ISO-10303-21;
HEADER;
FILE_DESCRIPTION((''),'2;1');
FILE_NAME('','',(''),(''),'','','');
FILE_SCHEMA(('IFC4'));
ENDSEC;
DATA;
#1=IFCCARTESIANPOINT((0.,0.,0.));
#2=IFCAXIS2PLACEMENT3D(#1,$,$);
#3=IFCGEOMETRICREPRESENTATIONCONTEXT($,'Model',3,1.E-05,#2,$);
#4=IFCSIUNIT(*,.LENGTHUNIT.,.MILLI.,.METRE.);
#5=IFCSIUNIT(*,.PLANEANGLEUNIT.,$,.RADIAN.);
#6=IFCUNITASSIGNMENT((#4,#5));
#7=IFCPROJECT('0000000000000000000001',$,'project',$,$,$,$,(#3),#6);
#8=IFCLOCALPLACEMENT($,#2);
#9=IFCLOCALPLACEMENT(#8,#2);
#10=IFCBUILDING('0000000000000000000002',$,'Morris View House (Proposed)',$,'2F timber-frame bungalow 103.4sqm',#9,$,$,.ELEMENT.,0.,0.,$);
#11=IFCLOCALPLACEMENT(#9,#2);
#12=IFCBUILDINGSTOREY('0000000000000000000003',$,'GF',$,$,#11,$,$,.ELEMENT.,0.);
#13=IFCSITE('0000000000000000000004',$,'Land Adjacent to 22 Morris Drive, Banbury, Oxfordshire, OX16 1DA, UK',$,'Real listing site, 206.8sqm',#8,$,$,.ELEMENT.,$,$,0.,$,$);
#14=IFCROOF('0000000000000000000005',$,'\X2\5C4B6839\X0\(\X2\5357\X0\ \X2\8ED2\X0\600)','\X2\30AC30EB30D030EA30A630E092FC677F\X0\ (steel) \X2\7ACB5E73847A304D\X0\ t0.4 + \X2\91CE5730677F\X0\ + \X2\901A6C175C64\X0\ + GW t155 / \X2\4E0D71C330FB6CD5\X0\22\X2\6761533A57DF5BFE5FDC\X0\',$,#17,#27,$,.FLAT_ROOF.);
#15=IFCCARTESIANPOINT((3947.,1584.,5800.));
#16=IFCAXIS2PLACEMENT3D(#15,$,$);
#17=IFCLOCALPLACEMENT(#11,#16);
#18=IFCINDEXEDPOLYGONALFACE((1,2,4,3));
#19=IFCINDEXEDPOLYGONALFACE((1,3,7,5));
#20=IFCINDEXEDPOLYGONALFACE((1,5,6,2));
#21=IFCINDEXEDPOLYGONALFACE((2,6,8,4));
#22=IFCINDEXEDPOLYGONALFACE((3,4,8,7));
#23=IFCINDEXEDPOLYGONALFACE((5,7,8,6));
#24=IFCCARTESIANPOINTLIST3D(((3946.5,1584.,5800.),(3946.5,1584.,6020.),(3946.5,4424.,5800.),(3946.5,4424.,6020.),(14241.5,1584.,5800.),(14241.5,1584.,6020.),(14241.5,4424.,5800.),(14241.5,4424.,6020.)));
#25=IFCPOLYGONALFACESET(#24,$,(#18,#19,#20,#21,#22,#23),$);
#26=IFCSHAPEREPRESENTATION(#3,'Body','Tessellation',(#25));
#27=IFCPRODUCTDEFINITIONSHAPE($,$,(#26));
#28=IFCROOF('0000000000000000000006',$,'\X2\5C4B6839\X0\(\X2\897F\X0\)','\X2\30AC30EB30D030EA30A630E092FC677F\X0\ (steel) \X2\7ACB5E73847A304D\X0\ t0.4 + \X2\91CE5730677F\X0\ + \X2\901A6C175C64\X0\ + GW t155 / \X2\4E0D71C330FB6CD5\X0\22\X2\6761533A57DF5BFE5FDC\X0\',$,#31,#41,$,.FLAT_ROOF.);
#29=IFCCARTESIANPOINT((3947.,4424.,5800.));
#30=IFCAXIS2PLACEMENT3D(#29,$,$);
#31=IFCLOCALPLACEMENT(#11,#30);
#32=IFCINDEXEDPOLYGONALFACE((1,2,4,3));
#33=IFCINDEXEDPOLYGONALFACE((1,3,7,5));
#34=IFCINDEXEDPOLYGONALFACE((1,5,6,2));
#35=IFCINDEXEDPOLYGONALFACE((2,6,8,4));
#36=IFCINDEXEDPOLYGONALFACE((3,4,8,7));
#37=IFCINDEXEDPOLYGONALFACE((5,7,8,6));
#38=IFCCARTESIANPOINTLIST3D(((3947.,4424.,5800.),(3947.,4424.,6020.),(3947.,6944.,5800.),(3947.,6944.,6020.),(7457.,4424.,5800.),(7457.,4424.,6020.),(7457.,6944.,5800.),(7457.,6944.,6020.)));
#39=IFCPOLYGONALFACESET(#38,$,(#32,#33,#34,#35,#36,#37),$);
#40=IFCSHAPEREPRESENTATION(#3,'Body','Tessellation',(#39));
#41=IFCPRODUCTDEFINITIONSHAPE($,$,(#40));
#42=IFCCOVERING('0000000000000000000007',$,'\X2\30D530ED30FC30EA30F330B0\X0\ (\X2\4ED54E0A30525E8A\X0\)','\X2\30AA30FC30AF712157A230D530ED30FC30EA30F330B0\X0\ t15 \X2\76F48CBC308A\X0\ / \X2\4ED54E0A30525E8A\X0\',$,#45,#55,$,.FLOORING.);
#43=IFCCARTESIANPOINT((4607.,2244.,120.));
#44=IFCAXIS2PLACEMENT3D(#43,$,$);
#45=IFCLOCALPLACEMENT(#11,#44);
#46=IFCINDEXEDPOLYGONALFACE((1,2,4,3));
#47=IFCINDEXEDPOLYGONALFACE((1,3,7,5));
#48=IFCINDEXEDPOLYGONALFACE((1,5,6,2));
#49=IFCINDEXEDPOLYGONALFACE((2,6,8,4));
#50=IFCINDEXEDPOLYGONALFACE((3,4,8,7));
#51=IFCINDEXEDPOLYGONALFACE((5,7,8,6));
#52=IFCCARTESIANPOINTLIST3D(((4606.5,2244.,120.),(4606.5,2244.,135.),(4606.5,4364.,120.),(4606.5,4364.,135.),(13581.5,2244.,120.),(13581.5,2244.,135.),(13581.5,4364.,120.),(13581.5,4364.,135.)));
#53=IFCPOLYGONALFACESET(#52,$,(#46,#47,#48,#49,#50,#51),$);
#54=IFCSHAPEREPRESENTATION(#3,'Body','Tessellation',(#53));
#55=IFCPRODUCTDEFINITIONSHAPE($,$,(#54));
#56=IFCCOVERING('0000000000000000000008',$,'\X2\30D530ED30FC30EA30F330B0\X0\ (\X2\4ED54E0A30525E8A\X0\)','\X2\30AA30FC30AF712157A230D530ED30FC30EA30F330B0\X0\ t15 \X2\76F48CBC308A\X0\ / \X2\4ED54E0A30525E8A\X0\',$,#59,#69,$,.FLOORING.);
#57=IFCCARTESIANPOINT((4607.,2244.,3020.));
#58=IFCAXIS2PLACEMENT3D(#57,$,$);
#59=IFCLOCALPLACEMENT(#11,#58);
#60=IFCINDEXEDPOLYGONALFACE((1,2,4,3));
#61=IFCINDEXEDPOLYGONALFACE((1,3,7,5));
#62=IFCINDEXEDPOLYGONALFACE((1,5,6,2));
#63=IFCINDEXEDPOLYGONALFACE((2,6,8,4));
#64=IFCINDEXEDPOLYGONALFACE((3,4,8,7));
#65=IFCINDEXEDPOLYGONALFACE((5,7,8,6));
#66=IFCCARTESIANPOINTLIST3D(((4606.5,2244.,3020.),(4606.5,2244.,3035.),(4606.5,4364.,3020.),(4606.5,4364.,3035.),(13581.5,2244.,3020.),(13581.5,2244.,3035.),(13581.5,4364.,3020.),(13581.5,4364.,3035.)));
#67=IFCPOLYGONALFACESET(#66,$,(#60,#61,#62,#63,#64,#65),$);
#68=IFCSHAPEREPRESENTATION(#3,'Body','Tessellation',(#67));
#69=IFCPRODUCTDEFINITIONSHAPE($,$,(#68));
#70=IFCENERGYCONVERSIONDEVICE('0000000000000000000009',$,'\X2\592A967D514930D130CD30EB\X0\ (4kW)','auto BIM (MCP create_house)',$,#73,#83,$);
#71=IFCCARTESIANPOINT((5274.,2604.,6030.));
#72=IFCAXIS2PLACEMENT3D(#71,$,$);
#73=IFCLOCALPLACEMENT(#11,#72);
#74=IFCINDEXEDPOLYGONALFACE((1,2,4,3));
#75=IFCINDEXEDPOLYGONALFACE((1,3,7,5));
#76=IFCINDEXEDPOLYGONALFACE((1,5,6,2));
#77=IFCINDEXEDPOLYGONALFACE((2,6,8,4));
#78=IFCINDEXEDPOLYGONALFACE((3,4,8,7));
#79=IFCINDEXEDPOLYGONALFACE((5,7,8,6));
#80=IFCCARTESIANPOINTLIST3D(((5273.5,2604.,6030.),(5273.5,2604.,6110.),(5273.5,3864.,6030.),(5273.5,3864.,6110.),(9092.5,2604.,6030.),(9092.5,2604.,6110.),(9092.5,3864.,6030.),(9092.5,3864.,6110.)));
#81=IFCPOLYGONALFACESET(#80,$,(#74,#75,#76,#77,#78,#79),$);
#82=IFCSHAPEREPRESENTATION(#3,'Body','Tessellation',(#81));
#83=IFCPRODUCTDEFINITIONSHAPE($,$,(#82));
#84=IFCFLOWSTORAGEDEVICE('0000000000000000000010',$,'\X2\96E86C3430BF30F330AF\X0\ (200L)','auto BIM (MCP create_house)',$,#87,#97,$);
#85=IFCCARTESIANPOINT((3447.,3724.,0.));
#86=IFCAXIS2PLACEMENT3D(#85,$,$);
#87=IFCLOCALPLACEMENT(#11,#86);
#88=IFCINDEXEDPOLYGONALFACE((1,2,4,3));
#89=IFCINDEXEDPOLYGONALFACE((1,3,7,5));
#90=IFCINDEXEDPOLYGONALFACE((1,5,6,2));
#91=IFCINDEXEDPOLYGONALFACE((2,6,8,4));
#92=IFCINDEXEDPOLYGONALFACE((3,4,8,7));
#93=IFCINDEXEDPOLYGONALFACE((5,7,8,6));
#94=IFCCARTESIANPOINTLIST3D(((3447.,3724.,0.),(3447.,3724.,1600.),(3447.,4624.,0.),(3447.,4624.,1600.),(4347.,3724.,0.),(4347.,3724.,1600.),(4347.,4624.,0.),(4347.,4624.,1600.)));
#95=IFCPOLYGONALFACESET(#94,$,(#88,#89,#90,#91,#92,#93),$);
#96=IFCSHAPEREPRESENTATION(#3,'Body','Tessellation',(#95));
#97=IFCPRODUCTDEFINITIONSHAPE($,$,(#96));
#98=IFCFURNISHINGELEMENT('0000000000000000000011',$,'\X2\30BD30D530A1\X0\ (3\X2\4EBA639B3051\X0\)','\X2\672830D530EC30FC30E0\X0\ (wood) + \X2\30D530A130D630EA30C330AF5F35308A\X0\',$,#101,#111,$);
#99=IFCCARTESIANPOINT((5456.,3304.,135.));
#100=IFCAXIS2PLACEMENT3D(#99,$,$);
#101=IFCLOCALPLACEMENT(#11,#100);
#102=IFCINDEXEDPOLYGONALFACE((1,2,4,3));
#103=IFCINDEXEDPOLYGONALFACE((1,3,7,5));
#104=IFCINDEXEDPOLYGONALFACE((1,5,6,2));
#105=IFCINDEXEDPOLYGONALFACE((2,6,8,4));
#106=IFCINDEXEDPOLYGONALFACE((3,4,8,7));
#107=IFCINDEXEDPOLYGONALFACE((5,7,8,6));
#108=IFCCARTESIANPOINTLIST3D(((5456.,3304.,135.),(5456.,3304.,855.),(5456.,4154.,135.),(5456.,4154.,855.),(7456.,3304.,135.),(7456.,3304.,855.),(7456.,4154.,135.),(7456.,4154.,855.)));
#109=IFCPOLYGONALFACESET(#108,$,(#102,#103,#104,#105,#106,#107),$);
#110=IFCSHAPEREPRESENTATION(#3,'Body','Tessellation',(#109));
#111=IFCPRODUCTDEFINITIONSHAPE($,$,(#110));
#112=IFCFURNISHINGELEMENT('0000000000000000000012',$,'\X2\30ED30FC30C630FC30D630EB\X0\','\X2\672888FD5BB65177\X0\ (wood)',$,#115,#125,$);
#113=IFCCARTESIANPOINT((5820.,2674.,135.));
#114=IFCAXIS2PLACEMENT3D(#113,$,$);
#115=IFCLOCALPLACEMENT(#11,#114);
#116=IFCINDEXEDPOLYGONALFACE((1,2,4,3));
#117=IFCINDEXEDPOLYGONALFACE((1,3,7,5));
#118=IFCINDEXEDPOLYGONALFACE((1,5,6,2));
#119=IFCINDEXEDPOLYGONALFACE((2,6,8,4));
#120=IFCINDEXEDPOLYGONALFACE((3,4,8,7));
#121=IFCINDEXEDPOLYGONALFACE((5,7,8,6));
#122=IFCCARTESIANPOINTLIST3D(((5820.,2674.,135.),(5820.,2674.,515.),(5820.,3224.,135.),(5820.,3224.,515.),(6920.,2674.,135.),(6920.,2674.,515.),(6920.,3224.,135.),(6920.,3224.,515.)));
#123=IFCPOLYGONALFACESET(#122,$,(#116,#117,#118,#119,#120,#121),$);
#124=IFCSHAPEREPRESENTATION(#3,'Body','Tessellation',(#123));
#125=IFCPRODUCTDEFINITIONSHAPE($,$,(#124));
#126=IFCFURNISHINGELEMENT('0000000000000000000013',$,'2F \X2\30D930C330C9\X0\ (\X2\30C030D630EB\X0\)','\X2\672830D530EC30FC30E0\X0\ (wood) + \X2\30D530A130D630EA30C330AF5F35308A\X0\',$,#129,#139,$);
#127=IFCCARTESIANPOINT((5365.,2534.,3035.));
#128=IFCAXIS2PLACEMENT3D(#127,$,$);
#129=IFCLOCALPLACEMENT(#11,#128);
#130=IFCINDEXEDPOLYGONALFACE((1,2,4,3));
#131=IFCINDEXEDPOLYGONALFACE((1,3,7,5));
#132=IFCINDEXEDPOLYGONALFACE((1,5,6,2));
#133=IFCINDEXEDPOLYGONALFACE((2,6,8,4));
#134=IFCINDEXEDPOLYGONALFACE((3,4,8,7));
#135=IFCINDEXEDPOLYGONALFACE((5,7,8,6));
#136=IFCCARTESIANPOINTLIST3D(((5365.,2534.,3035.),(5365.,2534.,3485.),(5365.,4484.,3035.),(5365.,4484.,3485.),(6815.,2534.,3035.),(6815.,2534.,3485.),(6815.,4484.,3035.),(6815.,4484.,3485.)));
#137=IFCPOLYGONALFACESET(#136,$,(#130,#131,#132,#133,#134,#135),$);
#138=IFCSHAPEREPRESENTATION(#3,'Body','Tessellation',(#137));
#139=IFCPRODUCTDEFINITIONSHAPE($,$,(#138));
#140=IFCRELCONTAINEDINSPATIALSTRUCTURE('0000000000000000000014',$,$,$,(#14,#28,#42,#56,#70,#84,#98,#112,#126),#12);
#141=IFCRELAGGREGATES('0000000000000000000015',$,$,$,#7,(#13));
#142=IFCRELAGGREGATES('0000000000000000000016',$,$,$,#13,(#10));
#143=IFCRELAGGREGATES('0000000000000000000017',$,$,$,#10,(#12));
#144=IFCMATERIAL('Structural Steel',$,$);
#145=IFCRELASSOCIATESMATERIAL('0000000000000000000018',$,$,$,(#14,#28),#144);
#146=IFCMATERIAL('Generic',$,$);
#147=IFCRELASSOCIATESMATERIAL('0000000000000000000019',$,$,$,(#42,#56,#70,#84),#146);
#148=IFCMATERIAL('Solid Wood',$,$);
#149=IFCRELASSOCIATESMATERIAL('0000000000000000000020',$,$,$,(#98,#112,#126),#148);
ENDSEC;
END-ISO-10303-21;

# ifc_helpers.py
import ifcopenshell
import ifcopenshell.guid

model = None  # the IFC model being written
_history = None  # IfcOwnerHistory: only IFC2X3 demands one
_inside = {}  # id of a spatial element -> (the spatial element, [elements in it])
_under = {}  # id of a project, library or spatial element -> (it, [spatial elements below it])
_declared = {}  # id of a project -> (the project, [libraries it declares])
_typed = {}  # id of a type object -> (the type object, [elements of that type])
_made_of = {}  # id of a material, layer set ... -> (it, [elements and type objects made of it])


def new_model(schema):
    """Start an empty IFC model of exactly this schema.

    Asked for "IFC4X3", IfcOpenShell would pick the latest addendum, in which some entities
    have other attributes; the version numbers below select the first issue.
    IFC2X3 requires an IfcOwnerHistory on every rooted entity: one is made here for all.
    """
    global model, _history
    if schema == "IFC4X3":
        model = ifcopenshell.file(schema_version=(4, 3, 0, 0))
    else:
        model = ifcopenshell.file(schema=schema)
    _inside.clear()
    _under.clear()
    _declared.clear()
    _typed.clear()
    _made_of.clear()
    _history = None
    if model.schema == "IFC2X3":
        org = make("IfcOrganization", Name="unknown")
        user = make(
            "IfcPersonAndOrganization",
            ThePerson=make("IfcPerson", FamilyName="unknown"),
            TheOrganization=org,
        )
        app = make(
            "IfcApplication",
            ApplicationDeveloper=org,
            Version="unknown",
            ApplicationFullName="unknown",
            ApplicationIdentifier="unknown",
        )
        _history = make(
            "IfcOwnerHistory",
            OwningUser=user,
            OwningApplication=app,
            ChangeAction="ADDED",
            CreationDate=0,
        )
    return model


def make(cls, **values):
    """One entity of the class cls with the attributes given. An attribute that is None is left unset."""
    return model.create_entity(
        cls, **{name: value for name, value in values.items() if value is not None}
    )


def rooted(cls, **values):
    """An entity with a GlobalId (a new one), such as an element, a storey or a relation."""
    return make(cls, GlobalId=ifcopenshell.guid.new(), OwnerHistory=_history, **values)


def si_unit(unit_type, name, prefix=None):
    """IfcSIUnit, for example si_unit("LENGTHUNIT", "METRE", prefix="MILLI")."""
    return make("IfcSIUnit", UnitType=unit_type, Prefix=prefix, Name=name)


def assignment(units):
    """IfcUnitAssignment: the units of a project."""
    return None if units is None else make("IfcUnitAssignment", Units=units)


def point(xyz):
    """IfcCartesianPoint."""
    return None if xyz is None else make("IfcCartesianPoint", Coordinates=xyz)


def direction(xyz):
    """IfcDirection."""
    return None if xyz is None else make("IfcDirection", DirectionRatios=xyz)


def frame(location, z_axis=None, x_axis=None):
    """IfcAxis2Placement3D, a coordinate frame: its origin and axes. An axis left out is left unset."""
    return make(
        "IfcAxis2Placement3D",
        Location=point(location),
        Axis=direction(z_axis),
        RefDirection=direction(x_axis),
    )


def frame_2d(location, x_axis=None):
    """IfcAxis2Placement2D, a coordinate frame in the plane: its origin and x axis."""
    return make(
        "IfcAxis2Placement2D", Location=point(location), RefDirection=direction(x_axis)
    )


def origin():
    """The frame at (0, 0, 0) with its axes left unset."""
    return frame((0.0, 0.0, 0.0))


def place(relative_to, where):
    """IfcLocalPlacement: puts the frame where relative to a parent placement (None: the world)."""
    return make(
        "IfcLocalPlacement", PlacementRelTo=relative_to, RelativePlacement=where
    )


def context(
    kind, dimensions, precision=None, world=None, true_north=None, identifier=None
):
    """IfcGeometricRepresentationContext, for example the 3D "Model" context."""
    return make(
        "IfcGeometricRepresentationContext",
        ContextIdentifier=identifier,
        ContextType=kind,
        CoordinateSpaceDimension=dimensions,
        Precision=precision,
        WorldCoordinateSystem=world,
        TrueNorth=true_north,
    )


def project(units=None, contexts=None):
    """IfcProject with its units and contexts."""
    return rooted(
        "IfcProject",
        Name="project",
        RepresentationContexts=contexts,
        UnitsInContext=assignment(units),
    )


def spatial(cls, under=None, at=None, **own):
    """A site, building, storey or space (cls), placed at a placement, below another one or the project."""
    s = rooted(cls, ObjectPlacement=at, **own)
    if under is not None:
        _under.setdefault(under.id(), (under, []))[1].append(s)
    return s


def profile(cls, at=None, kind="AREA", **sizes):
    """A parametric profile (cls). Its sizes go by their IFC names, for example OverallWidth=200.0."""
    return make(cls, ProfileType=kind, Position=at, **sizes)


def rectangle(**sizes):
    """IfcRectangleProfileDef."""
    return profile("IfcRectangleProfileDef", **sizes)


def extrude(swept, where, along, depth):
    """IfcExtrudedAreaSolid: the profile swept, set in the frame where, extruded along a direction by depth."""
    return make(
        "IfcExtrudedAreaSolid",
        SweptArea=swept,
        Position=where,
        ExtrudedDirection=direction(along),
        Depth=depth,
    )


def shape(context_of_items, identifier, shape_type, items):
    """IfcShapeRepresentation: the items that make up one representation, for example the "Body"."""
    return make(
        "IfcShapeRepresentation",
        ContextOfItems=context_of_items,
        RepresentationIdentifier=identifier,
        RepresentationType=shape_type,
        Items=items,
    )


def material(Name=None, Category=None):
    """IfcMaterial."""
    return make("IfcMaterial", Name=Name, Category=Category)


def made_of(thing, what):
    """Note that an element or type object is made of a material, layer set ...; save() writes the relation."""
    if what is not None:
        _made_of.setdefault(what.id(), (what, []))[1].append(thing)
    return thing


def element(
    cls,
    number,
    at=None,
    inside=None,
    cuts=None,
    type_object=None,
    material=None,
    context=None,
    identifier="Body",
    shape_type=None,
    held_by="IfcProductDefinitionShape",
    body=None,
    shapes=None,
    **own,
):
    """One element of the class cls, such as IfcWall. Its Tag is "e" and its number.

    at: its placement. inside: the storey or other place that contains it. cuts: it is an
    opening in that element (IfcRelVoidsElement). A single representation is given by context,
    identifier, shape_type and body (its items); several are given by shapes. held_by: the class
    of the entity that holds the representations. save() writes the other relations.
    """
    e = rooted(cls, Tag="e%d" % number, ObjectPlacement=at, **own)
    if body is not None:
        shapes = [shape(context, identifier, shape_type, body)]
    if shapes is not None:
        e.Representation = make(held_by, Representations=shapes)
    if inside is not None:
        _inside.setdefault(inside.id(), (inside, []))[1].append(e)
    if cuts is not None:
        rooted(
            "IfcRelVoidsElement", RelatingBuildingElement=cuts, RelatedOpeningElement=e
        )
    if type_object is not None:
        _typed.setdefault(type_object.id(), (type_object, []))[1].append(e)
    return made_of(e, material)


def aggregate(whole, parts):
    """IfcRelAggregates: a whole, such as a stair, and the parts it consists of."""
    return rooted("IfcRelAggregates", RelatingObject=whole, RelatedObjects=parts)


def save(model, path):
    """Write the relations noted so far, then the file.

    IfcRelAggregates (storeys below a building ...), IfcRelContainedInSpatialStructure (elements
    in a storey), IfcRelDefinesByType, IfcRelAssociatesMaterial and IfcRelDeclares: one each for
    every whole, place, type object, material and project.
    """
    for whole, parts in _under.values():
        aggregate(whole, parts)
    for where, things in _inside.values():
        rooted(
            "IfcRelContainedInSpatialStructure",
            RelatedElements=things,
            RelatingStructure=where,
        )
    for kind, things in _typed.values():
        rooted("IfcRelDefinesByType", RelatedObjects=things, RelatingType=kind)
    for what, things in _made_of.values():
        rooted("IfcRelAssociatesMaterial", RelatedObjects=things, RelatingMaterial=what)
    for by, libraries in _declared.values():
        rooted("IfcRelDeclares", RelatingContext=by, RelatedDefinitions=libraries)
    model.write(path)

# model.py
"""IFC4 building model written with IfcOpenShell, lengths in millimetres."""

from ifc_helpers import new_model, si_unit, frame, frame_2d, origin, place, context, project, spatial, rectangle, extrude, material, element, save


model = new_model("IFC4")

# Units and contexts
model_context = context("Model", 3, precision=1e-05, world=origin())
ifc_project = project(units=[si_unit("LENGTHUNIT", "METRE", prefix="MILLI"), si_unit("PLANEANGLEUNIT", "RADIAN")], contexts=[model_context])

# Site, building, storey
site_placement = place(None, origin())
site = spatial("IfcSite", under=ifc_project, at=site_placement, Name="Land Adjacent to 22 Morris Drive, Banbury, Oxfordshire, OX16 1DA, UK", ObjectType="Real listing site, 206.8sqm", CompositionType="ELEMENT", RefElevation=0.0)
building_placement = place(site_placement, origin())
building = spatial("IfcBuilding", under=site, at=building_placement, Name="Morris View House (Proposed)", ObjectType="2F timber-frame bungalow 103.4sqm", CompositionType="ELEMENT", ElevationOfRefHeight=0.0, ElevationOfTerrain=0.0)
storey_placement = place(building_placement, origin())
storey = spatial("IfcBuildingStorey", under=building, at=storey_placement, Name="GF", CompositionType="ELEMENT", Elevation=0.0)

# Shared definitions
ifc_material_1 = material(Name="Solid Wood")

# Roofs
ifc_material_2 = material(Name="Structural Steel")
roof_1_placement = place(storey_placement, frame((3947.0, 1584.0, 5800.0)))
element("IfcRoof", 1, at=roof_1_placement, inside=storey, material=ifc_material_2, Name="屋根(南 軒600)", Description="ガルバリウム鋼板 (steel) 立平葺き t0.4 + 野地板 + 通気層 + GW t155 / 不燃・法22条区域対応", PredefinedType="FLAT_ROOF", context=model_context, shape_type="SweptSolid", body=[
    extrude(rectangle(XDim=10295.0, YDim=2840.0, at=frame_2d((5147.0, 1420.0))), frame((3947.0, 1584.0, 5800.0)), (0.0, 0.0, 1.0), 220.0),
])
roof_2_placement = place(storey_placement, frame((3947.0, 4424.0, 5800.0)))
element("IfcRoof", 2, at=roof_2_placement, inside=storey, material=ifc_material_2, Name="屋根(西)", Description="ガルバリウム鋼板 (steel) 立平葺き t0.4 + 野地板 + 通気層 + GW t155 / 不燃・法22条区域対応", PredefinedType="FLAT_ROOF", context=model_context, shape_type="SweptSolid", body=[
    extrude(rectangle(XDim=3510.0, YDim=2520.0, at=frame_2d((1755.0, 1260.0))), frame((3947.0, 4424.0, 5800.0)), (0.0, 0.0, 1.0), 220.0),
])

# Coverings
ifc_material_3 = material(Name="Generic")
covering_1_placement = place(storey_placement, frame((4607.0, 2244.0, 120.0)))
element("IfcCovering", 3, at=covering_1_placement, inside=storey, material=ifc_material_3, Name="フローリング (仕上げ床)", Description="オーク無垢フローリング t15 直貼り / 仕上げ床", PredefinedType="FLOORING", context=model_context, shape_type="SweptSolid", body=[
    extrude(rectangle(XDim=8975.0, YDim=2120.0, at=frame_2d((4487.0, 1060.0))), frame((4607.0, 2244.0, 120.0)), (0.0, 0.0, 1.0), 15.0),
])
covering_2_placement = place(storey_placement, frame((4607.0, 2244.0, 3020.0)))
element("IfcCovering", 4, at=covering_2_placement, inside=storey, material=ifc_material_3, Name="フローリング (仕上げ床)", Description="オーク無垢フローリング t15 直貼り / 仕上げ床", PredefinedType="FLOORING", context=model_context, shape_type="SweptSolid", body=[
    extrude(rectangle(XDim=8975.0, YDim=2120.0, at=frame_2d((4487.0, 1060.0))), frame((4607.0, 2244.0, 3020.0)), (0.0, 0.0, 1.0), 15.0),
])

# Energy conversion device
energy_conversion_device_placement = place(storey_placement, frame((5274.0, 2604.0, 6030.0)))
element("IfcEnergyConversionDevice", 5, at=energy_conversion_device_placement, inside=storey, material=ifc_material_3, Name="太陽光パネル (4kW)", Description="auto BIM (MCP create_house)", context=model_context, shape_type="SweptSolid", body=[
    extrude(rectangle(XDim=3819.0, YDim=1260.0, at=frame_2d((1909.0, 630.0))), frame((5274.0, 2604.0, 6030.0)), (0.0, 0.0, 1.0), 80.0),
])

# Flow storage device
flow_storage_device_placement = place(storey_placement, frame((3447.0, 3724.0, 0.0)))
element("IfcFlowStorageDevice", 6, at=flow_storage_device_placement, inside=storey, material=ifc_material_3, Name="雨水タンク (200L)", Description="auto BIM (MCP create_house)", context=model_context, shape_type="SweptSolid", body=[
    extrude(rectangle(XDim=900.0, YDim=900.0, at=frame_2d((450.0, 450.0))), frame((3447.0, 3724.0, 0.0)), (0.0, 0.0, 1.0), 1600.0),
])

# Furnishing elements
furnishing_1_placement = place(storey_placement, frame((5456.0, 3304.0, 135.0)))
element("IfcFurnishingElement", 7, at=furnishing_1_placement, inside=storey, material=ifc_material_1, Name="ソファ (3人掛け)", Description="木フレーム (wood) + ファブリック張り", context=model_context, shape_type="SweptSolid", body=[
    extrude(rectangle(XDim=2000.0, YDim=850.0, at=frame_2d((1000.0, 425.0))), frame((5456.0, 3304.0, 135.0)), (0.0, 0.0, 1.0), 720.0),
])
furnishing_2_placement = place(storey_placement, frame((5820.0, 2674.0, 135.0)))
element("IfcFurnishingElement", 8, at=furnishing_2_placement, inside=storey, material=ifc_material_1, Name="ローテーブル", Description="木製家具 (wood)", context=model_context, shape_type="SweptSolid", body=[
    extrude(rectangle(XDim=1100.0, YDim=550.0, at=frame_2d((550.0, 275.0))), frame((5820.0, 2674.0, 135.0)), (0.0, 0.0, 1.0), 380.0),
])
furnishing_3_placement = place(storey_placement, frame((5365.0, 2534.0, 3035.0)))
element("IfcFurnishingElement", 9, at=furnishing_3_placement, inside=storey, material=ifc_material_1, Name="2F ベッド (ダブル)", Description="木フレーム (wood) + ファブリック張り", context=model_context, shape_type="SweptSolid", body=[
    extrude(rectangle(XDim=1450.0, YDim=1950.0, at=frame_2d((725.0, 975.0))), frame((5365.0, 2534.0, 3035.0)), (0.0, 0.0, 1.0), 450.0),
])

save(model, "model.ifc")
